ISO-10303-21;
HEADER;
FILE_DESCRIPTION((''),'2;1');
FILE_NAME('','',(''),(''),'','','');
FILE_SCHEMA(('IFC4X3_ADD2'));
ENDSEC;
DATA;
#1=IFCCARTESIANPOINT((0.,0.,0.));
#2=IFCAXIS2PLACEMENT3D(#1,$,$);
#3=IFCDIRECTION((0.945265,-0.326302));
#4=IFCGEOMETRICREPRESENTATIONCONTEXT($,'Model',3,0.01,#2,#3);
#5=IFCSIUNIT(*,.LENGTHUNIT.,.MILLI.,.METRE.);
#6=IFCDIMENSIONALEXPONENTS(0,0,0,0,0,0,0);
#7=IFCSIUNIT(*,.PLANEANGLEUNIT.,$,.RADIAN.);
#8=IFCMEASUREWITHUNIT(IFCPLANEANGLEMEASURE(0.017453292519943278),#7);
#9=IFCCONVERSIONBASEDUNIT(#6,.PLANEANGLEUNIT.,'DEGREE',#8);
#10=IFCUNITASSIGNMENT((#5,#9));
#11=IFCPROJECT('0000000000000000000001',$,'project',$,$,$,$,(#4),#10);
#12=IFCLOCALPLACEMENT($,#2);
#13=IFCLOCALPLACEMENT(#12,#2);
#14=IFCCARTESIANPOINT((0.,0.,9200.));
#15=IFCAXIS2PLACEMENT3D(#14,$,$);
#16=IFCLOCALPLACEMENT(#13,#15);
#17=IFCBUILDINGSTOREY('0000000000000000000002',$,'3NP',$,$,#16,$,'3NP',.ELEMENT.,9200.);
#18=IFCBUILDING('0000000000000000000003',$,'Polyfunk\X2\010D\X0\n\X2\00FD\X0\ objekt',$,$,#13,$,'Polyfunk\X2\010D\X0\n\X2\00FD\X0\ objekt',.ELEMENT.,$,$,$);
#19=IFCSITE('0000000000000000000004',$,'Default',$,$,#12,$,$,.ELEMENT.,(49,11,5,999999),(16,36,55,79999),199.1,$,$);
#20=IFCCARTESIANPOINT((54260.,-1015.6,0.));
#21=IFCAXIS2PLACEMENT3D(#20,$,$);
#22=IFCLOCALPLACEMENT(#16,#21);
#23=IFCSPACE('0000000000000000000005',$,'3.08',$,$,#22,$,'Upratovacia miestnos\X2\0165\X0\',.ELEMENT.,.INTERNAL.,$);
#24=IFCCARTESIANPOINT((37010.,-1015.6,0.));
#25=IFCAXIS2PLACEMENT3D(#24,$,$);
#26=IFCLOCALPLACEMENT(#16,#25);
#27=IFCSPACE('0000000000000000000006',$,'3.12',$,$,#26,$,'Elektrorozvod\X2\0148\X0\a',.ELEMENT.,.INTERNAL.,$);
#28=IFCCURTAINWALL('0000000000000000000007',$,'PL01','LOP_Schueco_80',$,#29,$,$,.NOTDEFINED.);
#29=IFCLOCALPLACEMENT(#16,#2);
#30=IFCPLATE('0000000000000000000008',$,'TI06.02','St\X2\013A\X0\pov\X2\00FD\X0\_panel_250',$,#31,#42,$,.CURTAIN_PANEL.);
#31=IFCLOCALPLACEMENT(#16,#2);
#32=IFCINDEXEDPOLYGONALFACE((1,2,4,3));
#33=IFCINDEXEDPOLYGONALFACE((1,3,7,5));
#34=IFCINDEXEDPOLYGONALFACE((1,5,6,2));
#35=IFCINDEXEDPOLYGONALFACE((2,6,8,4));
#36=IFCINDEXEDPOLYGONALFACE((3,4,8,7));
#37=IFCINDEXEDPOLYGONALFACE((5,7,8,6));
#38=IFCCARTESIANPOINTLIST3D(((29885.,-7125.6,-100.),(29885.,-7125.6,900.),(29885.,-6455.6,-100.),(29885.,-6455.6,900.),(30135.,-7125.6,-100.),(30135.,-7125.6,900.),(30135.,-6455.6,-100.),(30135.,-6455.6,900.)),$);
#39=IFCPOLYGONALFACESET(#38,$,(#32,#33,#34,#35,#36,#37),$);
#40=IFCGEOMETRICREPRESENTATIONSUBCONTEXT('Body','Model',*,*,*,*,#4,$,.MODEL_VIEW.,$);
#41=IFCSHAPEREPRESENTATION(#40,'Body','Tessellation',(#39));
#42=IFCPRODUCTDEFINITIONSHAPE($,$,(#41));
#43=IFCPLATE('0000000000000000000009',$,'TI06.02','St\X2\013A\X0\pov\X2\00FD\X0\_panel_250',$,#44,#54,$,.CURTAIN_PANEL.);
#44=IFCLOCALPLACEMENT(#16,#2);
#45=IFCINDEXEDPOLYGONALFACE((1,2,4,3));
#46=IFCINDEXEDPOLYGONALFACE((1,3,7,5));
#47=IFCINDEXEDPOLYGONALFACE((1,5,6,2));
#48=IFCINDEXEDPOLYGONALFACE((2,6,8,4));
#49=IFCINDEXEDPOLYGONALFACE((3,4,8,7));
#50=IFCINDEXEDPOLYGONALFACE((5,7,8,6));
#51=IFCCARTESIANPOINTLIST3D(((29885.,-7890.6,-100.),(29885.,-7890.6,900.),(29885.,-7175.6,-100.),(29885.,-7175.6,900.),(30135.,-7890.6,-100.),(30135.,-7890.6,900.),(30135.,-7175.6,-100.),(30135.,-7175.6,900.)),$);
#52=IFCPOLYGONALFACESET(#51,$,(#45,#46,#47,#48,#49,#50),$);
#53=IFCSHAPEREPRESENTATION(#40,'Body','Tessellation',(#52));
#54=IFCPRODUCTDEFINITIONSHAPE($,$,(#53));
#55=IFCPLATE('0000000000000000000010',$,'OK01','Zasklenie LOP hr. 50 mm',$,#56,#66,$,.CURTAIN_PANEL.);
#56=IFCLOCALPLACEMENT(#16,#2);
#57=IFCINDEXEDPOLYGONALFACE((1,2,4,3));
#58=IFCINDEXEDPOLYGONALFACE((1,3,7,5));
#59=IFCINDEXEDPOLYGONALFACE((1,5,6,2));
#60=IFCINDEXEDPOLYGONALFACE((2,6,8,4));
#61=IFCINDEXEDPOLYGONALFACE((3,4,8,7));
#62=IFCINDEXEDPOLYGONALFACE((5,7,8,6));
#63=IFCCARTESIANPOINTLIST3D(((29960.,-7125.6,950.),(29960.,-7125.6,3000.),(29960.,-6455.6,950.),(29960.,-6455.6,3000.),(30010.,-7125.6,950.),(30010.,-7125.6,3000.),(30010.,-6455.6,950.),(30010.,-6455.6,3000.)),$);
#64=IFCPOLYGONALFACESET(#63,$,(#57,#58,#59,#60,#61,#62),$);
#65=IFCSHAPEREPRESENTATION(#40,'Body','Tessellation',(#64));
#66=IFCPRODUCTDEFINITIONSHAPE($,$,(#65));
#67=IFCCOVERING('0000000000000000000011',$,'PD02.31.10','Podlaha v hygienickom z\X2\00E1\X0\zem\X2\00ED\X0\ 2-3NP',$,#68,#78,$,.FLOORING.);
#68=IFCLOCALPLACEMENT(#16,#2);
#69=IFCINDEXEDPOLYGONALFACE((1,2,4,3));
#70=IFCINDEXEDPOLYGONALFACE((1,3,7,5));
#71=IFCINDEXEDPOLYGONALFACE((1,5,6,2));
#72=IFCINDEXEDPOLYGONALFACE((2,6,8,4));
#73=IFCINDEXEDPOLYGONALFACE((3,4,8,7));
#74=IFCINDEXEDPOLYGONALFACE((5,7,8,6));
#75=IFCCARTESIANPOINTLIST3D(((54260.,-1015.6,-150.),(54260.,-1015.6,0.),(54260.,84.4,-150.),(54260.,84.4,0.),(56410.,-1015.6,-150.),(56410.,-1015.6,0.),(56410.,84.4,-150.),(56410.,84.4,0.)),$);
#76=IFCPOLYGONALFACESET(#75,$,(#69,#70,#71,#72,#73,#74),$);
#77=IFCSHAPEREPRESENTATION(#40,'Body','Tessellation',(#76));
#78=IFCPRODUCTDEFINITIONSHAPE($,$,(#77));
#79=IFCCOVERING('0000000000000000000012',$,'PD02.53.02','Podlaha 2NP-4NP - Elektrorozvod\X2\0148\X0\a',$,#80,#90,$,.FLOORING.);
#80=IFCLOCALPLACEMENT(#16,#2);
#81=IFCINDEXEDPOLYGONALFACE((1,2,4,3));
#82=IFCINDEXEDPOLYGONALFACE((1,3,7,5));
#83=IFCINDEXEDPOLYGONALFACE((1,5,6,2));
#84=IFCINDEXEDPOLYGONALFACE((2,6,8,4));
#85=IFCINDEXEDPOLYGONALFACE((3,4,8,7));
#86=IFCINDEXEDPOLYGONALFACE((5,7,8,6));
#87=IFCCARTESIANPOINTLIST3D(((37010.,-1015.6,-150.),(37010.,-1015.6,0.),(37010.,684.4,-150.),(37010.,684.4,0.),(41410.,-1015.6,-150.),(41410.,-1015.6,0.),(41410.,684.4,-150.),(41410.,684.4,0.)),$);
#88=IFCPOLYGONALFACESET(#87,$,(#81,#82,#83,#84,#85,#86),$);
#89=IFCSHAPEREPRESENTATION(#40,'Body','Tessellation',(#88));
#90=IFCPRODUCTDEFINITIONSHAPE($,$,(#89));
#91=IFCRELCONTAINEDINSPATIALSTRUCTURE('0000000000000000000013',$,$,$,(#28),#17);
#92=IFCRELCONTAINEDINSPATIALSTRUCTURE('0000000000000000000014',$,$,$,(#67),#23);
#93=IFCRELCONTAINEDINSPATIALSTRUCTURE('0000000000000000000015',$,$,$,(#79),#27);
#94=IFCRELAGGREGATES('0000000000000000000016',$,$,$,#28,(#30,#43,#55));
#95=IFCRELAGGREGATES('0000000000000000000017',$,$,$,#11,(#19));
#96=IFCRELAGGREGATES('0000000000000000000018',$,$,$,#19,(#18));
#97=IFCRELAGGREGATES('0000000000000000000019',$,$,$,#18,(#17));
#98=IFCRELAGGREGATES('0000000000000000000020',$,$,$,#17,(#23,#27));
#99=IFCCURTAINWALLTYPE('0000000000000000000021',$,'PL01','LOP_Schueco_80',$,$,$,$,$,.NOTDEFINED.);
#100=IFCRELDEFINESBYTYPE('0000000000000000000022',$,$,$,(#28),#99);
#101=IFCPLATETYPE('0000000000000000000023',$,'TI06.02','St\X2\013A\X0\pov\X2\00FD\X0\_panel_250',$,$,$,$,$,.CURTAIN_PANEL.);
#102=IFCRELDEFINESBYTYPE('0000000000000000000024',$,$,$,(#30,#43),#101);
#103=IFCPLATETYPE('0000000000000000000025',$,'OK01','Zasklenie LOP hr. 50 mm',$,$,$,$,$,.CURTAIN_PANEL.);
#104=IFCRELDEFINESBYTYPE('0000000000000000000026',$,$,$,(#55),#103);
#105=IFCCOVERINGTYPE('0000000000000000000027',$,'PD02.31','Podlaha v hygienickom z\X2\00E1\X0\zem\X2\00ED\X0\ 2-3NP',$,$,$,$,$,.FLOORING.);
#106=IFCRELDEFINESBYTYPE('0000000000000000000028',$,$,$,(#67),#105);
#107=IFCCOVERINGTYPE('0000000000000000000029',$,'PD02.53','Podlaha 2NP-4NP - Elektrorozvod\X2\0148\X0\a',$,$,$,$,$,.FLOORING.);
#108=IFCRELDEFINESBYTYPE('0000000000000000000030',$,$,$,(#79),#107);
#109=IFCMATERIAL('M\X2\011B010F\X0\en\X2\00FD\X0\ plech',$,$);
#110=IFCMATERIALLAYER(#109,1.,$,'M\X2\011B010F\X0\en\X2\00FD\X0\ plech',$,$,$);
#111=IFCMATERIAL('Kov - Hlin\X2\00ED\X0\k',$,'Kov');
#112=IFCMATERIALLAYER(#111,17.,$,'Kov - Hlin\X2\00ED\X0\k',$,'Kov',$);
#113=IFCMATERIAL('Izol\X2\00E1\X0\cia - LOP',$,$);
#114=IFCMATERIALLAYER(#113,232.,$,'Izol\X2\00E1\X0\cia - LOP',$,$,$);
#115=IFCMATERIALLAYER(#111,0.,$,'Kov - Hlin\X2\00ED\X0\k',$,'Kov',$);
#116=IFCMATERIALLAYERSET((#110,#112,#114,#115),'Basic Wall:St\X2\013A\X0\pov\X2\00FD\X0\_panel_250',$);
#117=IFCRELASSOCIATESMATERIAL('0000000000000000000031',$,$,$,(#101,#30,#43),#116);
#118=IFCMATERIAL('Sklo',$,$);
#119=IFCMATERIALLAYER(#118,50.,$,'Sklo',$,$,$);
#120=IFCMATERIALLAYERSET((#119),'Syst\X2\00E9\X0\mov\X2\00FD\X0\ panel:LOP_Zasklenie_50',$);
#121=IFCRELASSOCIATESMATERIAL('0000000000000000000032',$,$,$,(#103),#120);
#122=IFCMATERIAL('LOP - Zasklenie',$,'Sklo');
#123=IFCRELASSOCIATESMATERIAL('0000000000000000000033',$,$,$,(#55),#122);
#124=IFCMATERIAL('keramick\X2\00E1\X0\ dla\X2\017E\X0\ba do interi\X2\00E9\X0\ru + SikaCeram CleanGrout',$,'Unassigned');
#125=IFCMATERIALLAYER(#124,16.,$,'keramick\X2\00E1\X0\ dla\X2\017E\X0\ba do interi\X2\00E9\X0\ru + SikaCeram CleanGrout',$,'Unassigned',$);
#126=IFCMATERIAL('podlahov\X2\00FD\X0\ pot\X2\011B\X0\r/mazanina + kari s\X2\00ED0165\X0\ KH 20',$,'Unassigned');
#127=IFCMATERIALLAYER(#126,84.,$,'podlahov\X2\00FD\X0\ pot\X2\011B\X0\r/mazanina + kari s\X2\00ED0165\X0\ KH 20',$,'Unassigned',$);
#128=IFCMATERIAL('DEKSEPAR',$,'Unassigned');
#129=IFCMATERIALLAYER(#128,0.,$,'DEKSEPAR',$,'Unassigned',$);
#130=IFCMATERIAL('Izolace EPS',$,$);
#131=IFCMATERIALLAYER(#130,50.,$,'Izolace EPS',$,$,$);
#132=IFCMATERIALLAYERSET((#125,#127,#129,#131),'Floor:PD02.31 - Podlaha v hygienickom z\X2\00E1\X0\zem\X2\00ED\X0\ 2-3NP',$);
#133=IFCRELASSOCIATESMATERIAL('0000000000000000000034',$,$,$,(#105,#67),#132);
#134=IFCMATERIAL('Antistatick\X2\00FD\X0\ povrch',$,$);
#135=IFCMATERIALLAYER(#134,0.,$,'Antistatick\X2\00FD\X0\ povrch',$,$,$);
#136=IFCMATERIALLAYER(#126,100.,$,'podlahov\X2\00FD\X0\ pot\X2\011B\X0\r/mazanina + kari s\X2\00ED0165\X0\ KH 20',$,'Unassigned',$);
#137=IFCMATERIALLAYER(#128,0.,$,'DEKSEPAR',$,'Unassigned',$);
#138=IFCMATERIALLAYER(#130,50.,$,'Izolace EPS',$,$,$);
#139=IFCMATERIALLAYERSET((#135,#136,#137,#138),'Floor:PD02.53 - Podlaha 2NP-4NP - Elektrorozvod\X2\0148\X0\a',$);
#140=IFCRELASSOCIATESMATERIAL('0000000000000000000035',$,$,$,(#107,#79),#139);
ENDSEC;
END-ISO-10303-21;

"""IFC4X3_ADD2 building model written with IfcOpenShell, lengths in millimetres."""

from ifc_helpers import new_model, entity, si_unit, converted_unit, direction, frame, frame_2d, origin, origin_2d_with_axis, place, context, subcontext, project, spatial, rectangle, extrude, source, transform, mapped, material, layer, layer_set, layer_usage, type_object, type_shapes, element, aggregate, save


model = new_model("IFC4X3_ADD2")

# Units and contexts
model_context = context("Model", 3, precision=0.01, world=origin(), true_north=direction((0.945265, -0.326302)))
body_context = subcontext(model_context, "Body", "Model", "MODEL_VIEW")
ifc_project = project(units=[si_unit("LENGTHUNIT", "METRE", prefix="MILLI"), converted_unit("PLANEANGLEUNIT", "DEGREE", entity("IfcPlaneAngleMeasure", 0.017453292519943278), si_unit("PLANEANGLEUNIT", "RADIAN"), dimensions=[0, 0, 0, 0, 0, 0, 0])], contexts=[model_context])

# Site, building, storey
site_placement = place(None, origin())
site = spatial("IfcSite", under=ifc_project, at=site_placement, Name="Default", CompositionType="ELEMENT", RefLatitude=(49, 11, 5, 999999), RefLongitude=(16, 36, 55, 79999), RefElevation=199.1)
building_placement = place(site_placement, origin())
building = spatial("IfcBuilding", under=site, at=building_placement, Name="Polyfunkčný objekt", LongName="Polyfunkčný objekt", CompositionType="ELEMENT")
storey_placement = place(building_placement, frame((0.0, 0.0, 9200.0)))
storey = spatial("IfcBuildingStorey", under=building, at=storey_placement, Name="3NP", LongName="3NP", CompositionType="ELEMENT", Elevation=9200.0)

# Shared definitions
curtain_wall_type = type_object("IfcCurtainWallType", Name="PL01", Description="LOP_Schueco_80", PredefinedType="NOTDEFINED")

# Curtain wall
curtain_wall_1_placement = place(storey_placement, frame((0.0, 0.0, -9200.0)))
curtain_wall_1 = element("IfcCurtainWall", 1, at=curtain_wall_1_placement, inside=storey, type_object=curtain_wall_type, Name="PL01", Description="LOP_Schueco_80", PredefinedType="NOTDEFINED")

# Shared definitions
ifc_material_1 = material(Name="Měďený plech")
ifc_layer_1 = layer(ifc_material_1, 1.0, Name="Měďený plech")
ifc_material_2 = material(Name="Kov - Hliník", Category="Kov")
ifc_layer_2 = layer(ifc_material_2, 17.0, Name="Kov - Hliník", Category="Kov")
ifc_material_3 = material(Name="Izolácia - LOP")
ifc_layer_3 = layer(ifc_material_3, 232.0, Name="Izolácia - LOP")
ifc_layer_4 = layer(ifc_material_2, 0.0, Name="Kov - Hliník", Category="Kov")
ifc_layer_set_1 = layer_set([ifc_layer_1, ifc_layer_2, ifc_layer_3, ifc_layer_4], Name="Basic Wall:Stĺpový_panel_250")
plate_type_1 = type_object("IfcPlateType", Name="TI06.02", Description="Stĺpový_panel_250", PredefinedType="CURTAIN_PANEL", material=ifc_layer_set_1)

# Plates
ifc_layer_usage_1 = layer_usage(ifc_layer_set_1, "AXIS2", "POSITIVE", -125.0)
plate_1_placement = place(storey_placement, frame((30010.0, -6455.6, -100.0), z_axis=(0.0, 0.0, 1.0), x_axis=(0.0, -1.0, 0.0)))
plate_1 = element("IfcPlate", 2, at=plate_1_placement, type_object=plate_type_1, material=ifc_layer_usage_1, Name="TI06.02", Description="Stĺpový_panel_250", PredefinedType="CURTAIN_PANEL", context=body_context, shape_type="SweptSolid", body=[
    extrude(rectangle(XDim=250.0, YDim=670.0, at=frame_2d((0.0, 0.0), x_axis=(1.0, 0.0))), frame((335.0, 0.0, 0.0), z_axis=(0.0, 0.0, 1.0), x_axis=(0.0, 1.0, 0.0)), (0.0, 0.0, 1.0), 1000.0),
])
ifc_layer_usage_2 = layer_usage(ifc_layer_set_1, "AXIS2", "POSITIVE", -125.0)
plate_2_placement = place(storey_placement, frame((30010.0, -7175.6, -100.0), z_axis=(0.0, 0.0, 1.0), x_axis=(0.0, -1.0, 0.0)))
plate_2 = element("IfcPlate", 3, at=plate_2_placement, type_object=plate_type_1, material=ifc_layer_usage_2, Name="TI06.02", Description="Stĺpový_panel_250", PredefinedType="CURTAIN_PANEL", context=body_context, shape_type="SweptSolid", body=[
    extrude(rectangle(XDim=250.0, YDim=715.0, at=frame_2d((0.0, 0.0), x_axis=(1.0, 0.0))), frame((357.5, 0.0, 0.0), z_axis=(0.0, 0.0, 1.0), x_axis=(0.0, 1.0, 0.0)), (0.0, 0.0, 1.0), 1000.0),
])
ifc_material_4 = material(Name="LOP - Zasklenie", Category="Sklo")
ifc_material_5 = material(Name="Sklo")
ifc_layer_5 = layer(ifc_material_5, 50.0, Name="Sklo")
ifc_layer_set_2 = layer_set([ifc_layer_5], Name="Systémový panel:LOP_Zasklenie_50")
plate_type_2 = type_object("IfcPlateType", Name="OK01", Description="Zasklenie LOP hr. 50 mm", PredefinedType="CURTAIN_PANEL", material=ifc_layer_set_2)
shared_shape_1 = source(origin(), body_context, "Body", "SweptSolid", [
    extrude(rectangle(XDim=50.0, YDim=670.0, at=origin_2d_with_axis()), frame((0.0, -25.0, 0.0), z_axis=(0.0, 0.0, 1.0), x_axis=(0.0, 1.0, 0.0)), (0.0, 0.0, 1.0), 2050.0),
])
type_shapes(plate_type_2, [shared_shape_1])
plate_3_placement = place(curtain_wall_1_placement, frame((30010.0, -6790.6, 10150.0), z_axis=(0.0, 0.0, 1.0), x_axis=(0.0, -1.0, 0.0)))
plate_3 = element("IfcPlate", 4, at=plate_3_placement, type_object=plate_type_2, material=ifc_material_4, Name="OK01", Description="Zasklenie LOP hr. 50 mm", PredefinedType="CURTAIN_PANEL", context=body_context, shape_type="MappedRepresentation", body=[
    mapped(shared_shape_1, transform((0.0, 0.0, 0.0), scale=1.0)),
])
aggregate(curtain_wall_1, [plate_1, plate_2, plate_3])

# Shared definitions
ifc_material_6 = material(Name="keramická dlažba do interiéru + SikaCeram CleanGrout", Category="Unassigned")
ifc_layer_6 = layer(ifc_material_6, 16.0, Name="keramická dlažba do interiéru + SikaCeram CleanGrout", Category="Unassigned")
ifc_material_7 = material(Name="podlahový potěr/mazanina + kari síť KH 20", Category="Unassigned")
ifc_layer_7 = layer(ifc_material_7, 84.0, Name="podlahový potěr/mazanina + kari síť KH 20", Category="Unassigned")
ifc_material_8 = material(Name="DEKSEPAR", Category="Unassigned")
ifc_layer_8 = layer(ifc_material_8, 0.0, Name="DEKSEPAR", Category="Unassigned")
ifc_material_9 = material(Name="Izolace EPS")
ifc_layer_9 = layer(ifc_material_9, 50.0, Name="Izolace EPS")
ifc_layer_set_3 = layer_set([ifc_layer_6, ifc_layer_7, ifc_layer_8, ifc_layer_9], Name="Floor:PD02.31 - Podlaha v hygienickom zázemí 2-3NP")
covering_type_1 = type_object("IfcCoveringType", Name="PD02.31", Description="Podlaha v hygienickom zázemí 2-3NP", PredefinedType="FLOORING", material=ifc_layer_set_3)

# Shared definitions
space_1_placement = place(storey_placement, frame((54260.0, -1015.6, 0.0)))
space_1 = spatial("IfcSpace", under=storey, at=space_1_placement, Name="3.08", LongName="Upratovacia miestnosť", CompositionType="ELEMENT", PredefinedType="INTERNAL")

# Covering
ifc_layer_usage_3 = layer_usage(ifc_layer_set_3, "AXIS3", "POSITIVE", 0.0)
covering_1_placement = place(storey_placement, origin())
element("IfcCovering", 5, at=covering_1_placement, inside=space_1, type_object=covering_type_1, material=ifc_layer_usage_3, Name="PD02.31.10", Description="Podlaha v hygienickom zázemí 2-3NP", PredefinedType="FLOORING", context=body_context, shape_type="SweptSolid", body=[
    extrude(rectangle(XDim=1100.0, YDim=2150.0, at=frame_2d((0.0, 0.0), x_axis=(1.0, 0.0))), frame((55335.0, -465.6, 0.0), z_axis=(0.0, 0.0, -1.0), x_axis=(0.0, 1.0, 0.0)), (0.0, 0.0, 1.0), 150.0),
])

# Shared definitions
space_2_placement = place(storey_placement, frame((37010.0, -1015.6, 0.0)))
space_2 = spatial("IfcSpace", under=storey, at=space_2_placement, Name="3.12", LongName="Elektrorozvodňa", CompositionType="ELEMENT", PredefinedType="INTERNAL")

# Covering
ifc_material_10 = material(Name="Antistatický povrch")
ifc_layer_10 = layer(ifc_material_10, 0.0, Name="Antistatický povrch")
ifc_layer_11 = layer(ifc_material_7, 100.0, Name="podlahový potěr/mazanina + kari síť KH 20", Category="Unassigned")
ifc_layer_12 = layer(ifc_material_8, 0.0, Name="DEKSEPAR", Category="Unassigned")
ifc_layer_13 = layer(ifc_material_9, 50.0, Name="Izolace EPS")
ifc_layer_set_4 = layer_set([ifc_layer_10, ifc_layer_11, ifc_layer_12, ifc_layer_13], Name="Floor:PD02.53 - Podlaha 2NP-4NP - Elektrorozvodňa")
ifc_layer_usage_4 = layer_usage(ifc_layer_set_4, "AXIS3", "POSITIVE", 0.0)
covering_type_2 = type_object("IfcCoveringType", Name="PD02.53", Description="Podlaha 2NP-4NP - Elektrorozvodňa", PredefinedType="FLOORING", material=ifc_layer_set_4)
covering_2_placement = place(storey_placement, origin())
element("IfcCovering", 6, at=covering_2_placement, inside=space_2, type_object=covering_type_2, material=ifc_layer_usage_4, Name="PD02.53.02", Description="Podlaha 2NP-4NP - Elektrorozvodňa", PredefinedType="FLOORING", context=body_context, shape_type="SweptSolid", body=[
    extrude(rectangle(XDim=1700.0, YDim=4400.0, at=frame_2d((0.0, 0.0), x_axis=(1.0, 0.0))), frame((39210.0, -165.6, 0.0), z_axis=(0.0, 0.0, -1.0), x_axis=(0.0, 1.0, 0.0)), (0.0, 0.0, 1.0), 150.0),
])

save(model, "model.ifc")
